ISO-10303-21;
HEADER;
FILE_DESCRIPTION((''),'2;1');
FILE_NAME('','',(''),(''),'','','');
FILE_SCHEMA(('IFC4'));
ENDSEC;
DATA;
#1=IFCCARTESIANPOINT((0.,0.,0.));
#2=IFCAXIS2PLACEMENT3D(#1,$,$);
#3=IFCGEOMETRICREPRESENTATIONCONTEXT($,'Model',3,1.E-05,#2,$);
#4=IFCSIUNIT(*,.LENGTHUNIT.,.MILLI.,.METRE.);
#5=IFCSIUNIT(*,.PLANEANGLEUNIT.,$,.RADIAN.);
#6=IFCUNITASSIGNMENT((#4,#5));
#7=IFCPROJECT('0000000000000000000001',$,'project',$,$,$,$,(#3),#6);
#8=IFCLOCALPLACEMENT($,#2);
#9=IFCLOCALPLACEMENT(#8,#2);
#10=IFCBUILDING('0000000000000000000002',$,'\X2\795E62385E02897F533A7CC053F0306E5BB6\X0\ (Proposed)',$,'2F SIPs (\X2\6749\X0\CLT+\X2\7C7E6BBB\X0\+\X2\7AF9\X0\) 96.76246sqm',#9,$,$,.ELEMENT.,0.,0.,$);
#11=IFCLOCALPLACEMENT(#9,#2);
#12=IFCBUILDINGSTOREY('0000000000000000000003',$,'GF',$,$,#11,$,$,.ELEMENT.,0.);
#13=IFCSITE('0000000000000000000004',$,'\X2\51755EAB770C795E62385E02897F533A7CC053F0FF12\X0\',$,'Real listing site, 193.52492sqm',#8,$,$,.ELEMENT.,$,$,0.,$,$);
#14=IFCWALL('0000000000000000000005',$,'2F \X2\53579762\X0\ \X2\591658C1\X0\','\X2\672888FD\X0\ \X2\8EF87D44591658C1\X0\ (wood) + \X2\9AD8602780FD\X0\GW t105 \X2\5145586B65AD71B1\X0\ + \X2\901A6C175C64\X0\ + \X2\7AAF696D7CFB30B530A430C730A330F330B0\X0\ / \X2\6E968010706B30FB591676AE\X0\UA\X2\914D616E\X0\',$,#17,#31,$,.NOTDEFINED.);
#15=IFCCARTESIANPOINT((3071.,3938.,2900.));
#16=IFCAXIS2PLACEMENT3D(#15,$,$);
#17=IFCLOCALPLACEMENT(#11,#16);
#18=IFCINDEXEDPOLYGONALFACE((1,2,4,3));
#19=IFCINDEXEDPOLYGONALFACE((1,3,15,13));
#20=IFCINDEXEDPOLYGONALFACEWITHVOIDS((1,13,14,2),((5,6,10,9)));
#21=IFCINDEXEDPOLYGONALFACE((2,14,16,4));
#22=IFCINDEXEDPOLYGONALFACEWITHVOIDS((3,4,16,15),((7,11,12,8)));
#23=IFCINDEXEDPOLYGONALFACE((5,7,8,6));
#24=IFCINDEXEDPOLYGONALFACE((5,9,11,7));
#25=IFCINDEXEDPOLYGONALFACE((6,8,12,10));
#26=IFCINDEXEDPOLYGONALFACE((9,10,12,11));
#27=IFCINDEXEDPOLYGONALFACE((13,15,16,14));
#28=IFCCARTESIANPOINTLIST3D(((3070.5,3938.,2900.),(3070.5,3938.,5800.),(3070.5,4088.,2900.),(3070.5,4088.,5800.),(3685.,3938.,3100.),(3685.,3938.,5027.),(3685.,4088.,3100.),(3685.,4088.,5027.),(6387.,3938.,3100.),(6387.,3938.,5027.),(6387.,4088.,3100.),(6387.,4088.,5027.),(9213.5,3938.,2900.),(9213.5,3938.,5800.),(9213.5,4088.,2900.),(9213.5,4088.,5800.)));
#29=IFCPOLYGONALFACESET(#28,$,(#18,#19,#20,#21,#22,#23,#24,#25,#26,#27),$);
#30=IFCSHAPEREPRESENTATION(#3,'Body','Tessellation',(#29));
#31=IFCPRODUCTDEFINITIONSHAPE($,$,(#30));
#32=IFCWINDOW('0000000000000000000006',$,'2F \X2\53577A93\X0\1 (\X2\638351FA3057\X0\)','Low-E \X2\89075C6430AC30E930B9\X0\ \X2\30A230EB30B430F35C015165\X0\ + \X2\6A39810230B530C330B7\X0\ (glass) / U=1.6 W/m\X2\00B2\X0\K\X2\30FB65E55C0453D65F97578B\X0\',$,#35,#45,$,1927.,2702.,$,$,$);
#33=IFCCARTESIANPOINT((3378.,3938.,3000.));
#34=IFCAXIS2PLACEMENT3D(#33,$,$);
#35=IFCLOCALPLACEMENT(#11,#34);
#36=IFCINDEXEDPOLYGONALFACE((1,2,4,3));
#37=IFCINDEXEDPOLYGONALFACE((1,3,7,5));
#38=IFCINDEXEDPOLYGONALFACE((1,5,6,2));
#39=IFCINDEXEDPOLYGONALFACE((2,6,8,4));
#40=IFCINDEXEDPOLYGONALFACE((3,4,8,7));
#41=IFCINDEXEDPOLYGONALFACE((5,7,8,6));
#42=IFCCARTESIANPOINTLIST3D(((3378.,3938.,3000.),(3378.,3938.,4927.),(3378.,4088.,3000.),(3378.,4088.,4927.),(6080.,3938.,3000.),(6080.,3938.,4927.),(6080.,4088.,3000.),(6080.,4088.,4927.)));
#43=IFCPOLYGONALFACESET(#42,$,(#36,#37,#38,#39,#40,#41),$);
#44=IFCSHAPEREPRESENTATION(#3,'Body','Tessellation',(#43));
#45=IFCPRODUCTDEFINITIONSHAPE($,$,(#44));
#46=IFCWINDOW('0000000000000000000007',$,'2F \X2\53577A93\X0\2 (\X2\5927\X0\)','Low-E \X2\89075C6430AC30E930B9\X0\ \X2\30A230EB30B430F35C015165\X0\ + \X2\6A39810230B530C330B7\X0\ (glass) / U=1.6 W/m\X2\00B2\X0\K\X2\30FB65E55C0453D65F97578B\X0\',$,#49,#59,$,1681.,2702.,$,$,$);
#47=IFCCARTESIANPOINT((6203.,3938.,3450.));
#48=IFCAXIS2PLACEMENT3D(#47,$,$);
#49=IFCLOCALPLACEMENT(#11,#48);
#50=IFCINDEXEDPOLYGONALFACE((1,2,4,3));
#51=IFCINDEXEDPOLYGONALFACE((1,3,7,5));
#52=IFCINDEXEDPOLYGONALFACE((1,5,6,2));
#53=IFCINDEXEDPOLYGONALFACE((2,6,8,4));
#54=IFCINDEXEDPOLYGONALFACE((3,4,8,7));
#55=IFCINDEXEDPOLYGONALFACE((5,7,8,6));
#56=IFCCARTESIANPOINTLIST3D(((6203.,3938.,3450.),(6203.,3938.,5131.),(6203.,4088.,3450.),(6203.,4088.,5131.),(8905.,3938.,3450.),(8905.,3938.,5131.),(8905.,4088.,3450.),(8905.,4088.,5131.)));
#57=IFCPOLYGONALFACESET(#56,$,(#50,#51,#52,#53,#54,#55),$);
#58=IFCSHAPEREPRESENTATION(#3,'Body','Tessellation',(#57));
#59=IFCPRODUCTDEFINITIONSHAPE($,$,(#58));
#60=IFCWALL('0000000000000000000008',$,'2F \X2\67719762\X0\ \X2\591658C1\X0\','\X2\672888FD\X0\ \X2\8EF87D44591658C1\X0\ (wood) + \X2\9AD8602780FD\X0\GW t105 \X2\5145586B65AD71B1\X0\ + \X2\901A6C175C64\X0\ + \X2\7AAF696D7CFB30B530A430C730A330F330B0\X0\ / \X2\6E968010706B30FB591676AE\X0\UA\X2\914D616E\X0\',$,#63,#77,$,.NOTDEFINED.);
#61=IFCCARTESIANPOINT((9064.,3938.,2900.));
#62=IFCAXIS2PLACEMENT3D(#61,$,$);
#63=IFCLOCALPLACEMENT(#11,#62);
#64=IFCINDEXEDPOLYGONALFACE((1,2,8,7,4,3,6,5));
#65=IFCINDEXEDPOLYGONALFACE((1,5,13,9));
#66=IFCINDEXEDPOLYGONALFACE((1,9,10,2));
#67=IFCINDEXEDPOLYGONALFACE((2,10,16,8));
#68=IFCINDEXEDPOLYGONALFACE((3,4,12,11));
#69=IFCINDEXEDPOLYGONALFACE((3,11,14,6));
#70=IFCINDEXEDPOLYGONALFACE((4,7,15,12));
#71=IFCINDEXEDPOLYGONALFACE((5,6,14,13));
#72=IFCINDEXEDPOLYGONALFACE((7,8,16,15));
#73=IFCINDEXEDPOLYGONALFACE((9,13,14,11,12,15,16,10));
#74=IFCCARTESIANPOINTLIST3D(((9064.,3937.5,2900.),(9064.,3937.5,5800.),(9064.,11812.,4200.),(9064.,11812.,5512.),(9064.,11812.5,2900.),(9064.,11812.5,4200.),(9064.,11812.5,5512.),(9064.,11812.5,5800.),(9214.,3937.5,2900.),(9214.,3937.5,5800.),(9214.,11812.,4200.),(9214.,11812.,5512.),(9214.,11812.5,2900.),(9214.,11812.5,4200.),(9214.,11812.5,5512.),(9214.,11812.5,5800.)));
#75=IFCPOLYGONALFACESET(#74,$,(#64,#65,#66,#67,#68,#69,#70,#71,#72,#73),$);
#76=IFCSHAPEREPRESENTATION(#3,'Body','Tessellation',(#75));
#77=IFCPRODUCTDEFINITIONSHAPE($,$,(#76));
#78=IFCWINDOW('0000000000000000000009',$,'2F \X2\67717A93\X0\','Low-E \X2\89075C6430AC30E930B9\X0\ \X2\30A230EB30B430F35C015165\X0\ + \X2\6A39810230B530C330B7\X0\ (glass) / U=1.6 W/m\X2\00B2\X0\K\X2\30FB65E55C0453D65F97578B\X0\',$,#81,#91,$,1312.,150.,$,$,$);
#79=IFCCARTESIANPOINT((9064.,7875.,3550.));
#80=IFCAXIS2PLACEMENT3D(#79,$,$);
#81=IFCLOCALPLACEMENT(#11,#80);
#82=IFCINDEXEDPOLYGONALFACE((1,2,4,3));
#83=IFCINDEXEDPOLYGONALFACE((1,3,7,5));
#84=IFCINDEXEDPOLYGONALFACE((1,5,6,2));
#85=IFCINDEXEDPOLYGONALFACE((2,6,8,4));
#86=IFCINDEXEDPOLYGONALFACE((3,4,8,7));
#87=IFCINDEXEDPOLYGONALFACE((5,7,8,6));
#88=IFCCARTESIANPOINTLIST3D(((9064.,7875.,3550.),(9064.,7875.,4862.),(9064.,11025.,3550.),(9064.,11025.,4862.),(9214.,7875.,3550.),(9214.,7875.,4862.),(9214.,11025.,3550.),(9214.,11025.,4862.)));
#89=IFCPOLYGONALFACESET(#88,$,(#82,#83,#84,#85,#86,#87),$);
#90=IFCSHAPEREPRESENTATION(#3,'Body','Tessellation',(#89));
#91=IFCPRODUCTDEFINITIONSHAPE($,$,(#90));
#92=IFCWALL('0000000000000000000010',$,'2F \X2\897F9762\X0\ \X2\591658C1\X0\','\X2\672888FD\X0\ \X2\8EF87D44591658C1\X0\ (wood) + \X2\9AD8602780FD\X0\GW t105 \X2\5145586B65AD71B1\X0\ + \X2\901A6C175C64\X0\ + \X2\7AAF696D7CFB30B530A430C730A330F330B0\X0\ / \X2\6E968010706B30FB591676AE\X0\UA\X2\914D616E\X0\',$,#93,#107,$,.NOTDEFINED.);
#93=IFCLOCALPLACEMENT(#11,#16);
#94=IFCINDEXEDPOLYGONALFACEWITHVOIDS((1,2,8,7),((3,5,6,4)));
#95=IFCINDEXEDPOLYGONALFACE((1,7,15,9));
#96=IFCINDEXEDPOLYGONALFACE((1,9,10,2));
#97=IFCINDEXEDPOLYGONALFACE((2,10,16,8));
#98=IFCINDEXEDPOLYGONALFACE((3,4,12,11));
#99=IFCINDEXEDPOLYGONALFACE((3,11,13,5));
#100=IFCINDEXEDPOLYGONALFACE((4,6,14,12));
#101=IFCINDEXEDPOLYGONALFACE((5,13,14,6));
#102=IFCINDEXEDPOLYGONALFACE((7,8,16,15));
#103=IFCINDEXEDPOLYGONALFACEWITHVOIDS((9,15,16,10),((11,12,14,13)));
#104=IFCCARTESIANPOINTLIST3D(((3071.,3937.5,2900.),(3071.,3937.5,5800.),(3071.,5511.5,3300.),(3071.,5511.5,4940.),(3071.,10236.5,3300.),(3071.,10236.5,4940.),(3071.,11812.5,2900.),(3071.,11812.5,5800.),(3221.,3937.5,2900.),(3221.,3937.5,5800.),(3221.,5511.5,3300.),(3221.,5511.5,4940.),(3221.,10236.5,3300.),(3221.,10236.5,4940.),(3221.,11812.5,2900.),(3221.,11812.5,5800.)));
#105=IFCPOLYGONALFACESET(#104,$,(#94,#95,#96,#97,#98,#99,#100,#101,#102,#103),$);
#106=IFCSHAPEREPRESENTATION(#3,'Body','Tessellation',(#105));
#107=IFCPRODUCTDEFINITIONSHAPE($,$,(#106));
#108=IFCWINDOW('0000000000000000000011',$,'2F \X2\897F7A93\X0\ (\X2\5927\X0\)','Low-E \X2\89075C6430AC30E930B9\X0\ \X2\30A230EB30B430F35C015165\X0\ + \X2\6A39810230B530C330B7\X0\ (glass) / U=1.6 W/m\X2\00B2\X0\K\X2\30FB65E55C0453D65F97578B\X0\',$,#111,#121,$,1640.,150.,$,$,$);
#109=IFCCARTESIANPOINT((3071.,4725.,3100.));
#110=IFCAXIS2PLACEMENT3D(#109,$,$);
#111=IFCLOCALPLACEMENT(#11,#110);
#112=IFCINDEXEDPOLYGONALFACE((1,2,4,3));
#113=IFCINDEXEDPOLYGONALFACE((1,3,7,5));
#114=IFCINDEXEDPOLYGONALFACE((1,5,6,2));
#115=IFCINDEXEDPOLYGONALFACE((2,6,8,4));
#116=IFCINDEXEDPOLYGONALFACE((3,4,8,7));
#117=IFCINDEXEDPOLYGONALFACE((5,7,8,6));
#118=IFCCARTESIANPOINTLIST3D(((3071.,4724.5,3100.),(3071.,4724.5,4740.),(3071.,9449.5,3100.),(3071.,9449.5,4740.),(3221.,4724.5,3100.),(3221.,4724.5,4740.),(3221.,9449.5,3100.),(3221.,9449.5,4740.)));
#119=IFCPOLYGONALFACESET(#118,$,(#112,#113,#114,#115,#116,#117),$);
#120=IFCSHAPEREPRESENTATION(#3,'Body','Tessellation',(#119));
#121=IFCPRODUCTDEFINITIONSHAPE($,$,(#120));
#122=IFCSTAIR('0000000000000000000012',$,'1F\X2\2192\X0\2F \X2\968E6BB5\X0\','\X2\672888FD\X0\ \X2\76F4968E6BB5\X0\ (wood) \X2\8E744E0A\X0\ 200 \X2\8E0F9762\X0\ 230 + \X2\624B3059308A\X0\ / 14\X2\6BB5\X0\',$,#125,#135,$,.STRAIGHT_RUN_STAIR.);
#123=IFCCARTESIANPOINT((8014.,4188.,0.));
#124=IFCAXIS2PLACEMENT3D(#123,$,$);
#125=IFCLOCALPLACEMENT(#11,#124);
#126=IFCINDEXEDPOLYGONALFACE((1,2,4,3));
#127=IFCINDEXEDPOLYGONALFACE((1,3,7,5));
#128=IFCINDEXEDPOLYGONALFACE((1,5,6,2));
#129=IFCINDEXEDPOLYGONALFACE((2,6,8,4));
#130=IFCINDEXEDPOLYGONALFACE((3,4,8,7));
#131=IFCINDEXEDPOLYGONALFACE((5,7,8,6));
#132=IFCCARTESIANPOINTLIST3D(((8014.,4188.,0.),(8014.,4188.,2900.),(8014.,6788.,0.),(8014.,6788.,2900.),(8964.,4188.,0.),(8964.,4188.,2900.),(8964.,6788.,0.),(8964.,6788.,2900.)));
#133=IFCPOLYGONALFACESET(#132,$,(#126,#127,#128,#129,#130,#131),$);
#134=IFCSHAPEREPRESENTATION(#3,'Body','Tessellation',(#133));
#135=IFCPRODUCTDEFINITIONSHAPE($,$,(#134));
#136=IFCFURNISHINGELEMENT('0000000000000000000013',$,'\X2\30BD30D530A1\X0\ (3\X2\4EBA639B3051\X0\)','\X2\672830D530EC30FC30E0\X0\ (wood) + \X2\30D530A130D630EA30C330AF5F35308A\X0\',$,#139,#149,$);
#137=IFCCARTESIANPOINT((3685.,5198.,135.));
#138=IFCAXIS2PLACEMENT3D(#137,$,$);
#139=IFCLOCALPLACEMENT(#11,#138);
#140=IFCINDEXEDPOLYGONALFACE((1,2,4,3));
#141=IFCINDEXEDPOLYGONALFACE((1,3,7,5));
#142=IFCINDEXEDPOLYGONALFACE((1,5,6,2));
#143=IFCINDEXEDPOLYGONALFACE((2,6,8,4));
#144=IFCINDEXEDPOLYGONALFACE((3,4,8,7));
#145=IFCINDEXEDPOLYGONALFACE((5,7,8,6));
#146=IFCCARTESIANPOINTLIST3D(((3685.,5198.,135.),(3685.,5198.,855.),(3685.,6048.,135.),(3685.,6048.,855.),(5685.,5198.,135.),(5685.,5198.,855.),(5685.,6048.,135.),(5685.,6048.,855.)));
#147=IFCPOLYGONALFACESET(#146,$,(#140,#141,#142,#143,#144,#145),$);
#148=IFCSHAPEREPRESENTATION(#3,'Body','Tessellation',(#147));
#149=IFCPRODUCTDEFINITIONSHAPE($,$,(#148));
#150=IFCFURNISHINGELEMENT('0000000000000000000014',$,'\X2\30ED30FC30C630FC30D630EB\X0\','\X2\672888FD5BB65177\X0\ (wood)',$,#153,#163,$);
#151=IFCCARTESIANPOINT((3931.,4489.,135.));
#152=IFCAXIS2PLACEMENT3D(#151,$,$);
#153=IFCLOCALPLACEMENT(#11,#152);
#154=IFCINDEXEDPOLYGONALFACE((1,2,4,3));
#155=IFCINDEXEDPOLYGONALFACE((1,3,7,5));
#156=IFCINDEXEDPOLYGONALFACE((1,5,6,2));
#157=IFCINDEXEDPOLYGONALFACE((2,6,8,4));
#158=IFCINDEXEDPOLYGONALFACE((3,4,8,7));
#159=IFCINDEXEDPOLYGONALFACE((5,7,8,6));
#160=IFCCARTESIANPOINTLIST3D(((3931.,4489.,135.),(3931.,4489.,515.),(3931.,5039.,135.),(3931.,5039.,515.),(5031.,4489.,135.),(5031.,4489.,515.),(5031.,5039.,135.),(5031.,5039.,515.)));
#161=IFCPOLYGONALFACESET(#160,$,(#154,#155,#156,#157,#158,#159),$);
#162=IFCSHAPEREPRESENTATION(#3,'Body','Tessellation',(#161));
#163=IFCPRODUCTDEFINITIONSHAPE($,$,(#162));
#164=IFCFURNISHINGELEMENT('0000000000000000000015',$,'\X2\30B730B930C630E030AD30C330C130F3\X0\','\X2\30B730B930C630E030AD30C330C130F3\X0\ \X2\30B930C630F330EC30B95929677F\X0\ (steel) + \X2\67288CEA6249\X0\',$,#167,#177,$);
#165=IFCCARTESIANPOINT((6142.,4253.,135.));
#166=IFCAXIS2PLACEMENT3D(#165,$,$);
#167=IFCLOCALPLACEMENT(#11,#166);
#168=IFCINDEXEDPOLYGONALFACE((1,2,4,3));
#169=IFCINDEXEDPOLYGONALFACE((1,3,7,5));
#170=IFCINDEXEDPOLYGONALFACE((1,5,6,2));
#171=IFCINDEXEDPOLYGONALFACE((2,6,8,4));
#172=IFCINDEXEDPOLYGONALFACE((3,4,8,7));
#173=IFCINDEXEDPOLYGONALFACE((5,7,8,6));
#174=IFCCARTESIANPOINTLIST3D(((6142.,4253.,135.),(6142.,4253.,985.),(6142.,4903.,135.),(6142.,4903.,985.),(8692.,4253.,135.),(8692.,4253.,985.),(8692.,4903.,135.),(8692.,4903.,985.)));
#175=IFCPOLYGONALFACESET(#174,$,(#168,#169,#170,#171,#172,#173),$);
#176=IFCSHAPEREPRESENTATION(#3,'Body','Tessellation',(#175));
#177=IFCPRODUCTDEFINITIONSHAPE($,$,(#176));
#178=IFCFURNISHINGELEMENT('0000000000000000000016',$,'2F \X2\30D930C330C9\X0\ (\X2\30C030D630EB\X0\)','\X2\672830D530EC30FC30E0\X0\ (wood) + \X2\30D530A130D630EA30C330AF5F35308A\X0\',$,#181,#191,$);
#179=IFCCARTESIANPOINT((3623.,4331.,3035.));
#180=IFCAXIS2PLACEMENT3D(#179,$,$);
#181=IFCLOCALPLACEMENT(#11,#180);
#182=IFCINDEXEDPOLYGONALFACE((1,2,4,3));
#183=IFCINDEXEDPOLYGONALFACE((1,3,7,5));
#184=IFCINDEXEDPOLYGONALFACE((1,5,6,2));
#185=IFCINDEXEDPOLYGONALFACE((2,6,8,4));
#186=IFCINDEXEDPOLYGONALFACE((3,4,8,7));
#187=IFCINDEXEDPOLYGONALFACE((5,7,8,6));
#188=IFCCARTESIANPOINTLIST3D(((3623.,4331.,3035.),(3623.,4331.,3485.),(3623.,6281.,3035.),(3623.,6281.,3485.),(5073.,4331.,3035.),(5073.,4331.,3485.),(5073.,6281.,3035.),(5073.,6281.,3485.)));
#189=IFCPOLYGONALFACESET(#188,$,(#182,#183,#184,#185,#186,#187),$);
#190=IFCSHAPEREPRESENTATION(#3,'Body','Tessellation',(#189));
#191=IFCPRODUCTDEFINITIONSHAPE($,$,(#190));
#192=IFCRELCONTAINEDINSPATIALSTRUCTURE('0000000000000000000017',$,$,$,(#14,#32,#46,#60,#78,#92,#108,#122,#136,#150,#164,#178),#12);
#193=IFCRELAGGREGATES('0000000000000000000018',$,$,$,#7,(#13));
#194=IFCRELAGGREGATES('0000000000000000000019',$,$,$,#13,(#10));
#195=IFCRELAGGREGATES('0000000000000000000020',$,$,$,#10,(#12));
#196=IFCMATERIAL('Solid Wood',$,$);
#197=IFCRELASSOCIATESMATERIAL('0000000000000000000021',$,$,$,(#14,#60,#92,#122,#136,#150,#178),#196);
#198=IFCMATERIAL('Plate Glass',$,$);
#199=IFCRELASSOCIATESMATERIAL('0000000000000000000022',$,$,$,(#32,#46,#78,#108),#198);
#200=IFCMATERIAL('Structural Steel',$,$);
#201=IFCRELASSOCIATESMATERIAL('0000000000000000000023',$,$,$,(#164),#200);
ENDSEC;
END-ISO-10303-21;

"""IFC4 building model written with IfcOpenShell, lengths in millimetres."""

from ifc_helpers import new_model, si_unit, frame, frame_2d, origin, place, context, project, spatial, rectangle, extrude, material, element, fill, save


model = new_model("IFC4")

# Units and contexts
model_context = context("Model", 3, precision=1e-05, world=origin())
ifc_project = project(units=[si_unit("LENGTHUNIT", "METRE", prefix="MILLI"), si_unit("PLANEANGLEUNIT", "RADIAN")], contexts=[model_context])

# Site, building, storey
site_placement = place(None, origin())
site = spatial("IfcSite", under=ifc_project, at=site_placement, Name="兵庫県神戸市西区糀台２", ObjectType="Real listing site, 193.52492sqm", CompositionType="ELEMENT", RefElevation=0.0)
building_placement = place(site_placement, origin())
building = spatial("IfcBuilding", under=site, at=building_placement, Name="神戸市西区糀台の家 (Proposed)", ObjectType="2F SIPs (杉CLT+籾殻+竹) 96.76246sqm", CompositionType="ELEMENT", ElevationOfRefHeight=0.0, ElevationOfTerrain=0.0)
storey_placement = place(building_placement, origin())
storey = spatial("IfcBuildingStorey", under=building, at=storey_placement, Name="GF", CompositionType="ELEMENT", Elevation=0.0)

# Shared definitions
ifc_material_1 = material(Name="Solid Wood")

# Shared definitions
ifc_material_2 = material(Name="Plate Glass")

# Wall, openings, windows
wall_1_placement = place(storey_placement, frame((3071.0, 3938.0, 2900.0)))
wall_1 = element("IfcWall", 1, at=wall_1_placement, inside=storey, material=ifc_material_1, Name="2F 南面 外壁", Description="木製 軸組外壁 (wood) + 高性能GW t105 充填断熱 + 通気層 + 窯業系サイディング / 準耐火・外皮UA配慮", PredefinedType="NOTDEFINED", context=model_context, shape_type="SweptSolid", body=[
    extrude(rectangle(XDim=6143.0, YDim=150.0, at=frame_2d((3071.0, 75.0))), frame((3071.0, 3938.0, 2900.0)), (0.0, 0.0, 1.0), 2900.0),
])
opening_1_placement = place(storey_placement, frame((3378.0, 3938.0, 3000.0)))
opening_1 = element("IfcOpeningElement", 2, at=opening_1_placement, cuts=wall_1, PredefinedType="NOTDEFINED", context=model_context, shape_type="SweptSolid", body=[
    extrude(rectangle(XDim=2702.0, YDim=150.0, at=frame_2d((1351.0, 75.0))), frame((3378.0, 3938.0, 3000.0)), (0.0, 0.0, 1.0), 1927.0),
])
opening_2_placement = place(storey_placement, frame((6203.0, 3938.0, 3450.0)))
opening_2 = element("IfcOpeningElement", 3, at=opening_2_placement, cuts=wall_1, PredefinedType="NOTDEFINED", context=model_context, shape_type="SweptSolid", body=[
    extrude(rectangle(XDim=2702.0, YDim=150.0, at=frame_2d((1351.0, 75.0))), frame((6203.0, 3938.0, 3450.0)), (0.0, 0.0, 1.0), 1681.0),
])
window_1_placement = place(storey_placement, frame((3378.0, 3938.0, 3000.0)))
window_1 = element("IfcWindow", 4, at=window_1_placement, inside=storey, material=ifc_material_2, Name="2F 南窓1 (掃出し)", Description="Low-E 複層ガラス アルゴン封入 + 樹脂サッシ (glass) / U=1.6 W/m²K・日射取得型", OverallHeight=1927.0, OverallWidth=2702.0, context=model_context, shape_type="SweptSolid", body=[
    extrude(rectangle(XDim=2702.0, YDim=150.0, at=frame_2d((1351.0, 75.0))), frame((3378.0, 3938.0, 3000.0)), (0.0, 0.0, 1.0), 1927.0),
])
fill(opening_1, window_1)
window_2_placement = place(storey_placement, frame((6203.0, 3938.0, 3450.0)))
window_2 = element("IfcWindow", 5, at=window_2_placement, inside=storey, material=ifc_material_2, Name="2F 南窓2 (大)", Description="Low-E 複層ガラス アルゴン封入 + 樹脂サッシ (glass) / U=1.6 W/m²K・日射取得型", OverallHeight=1681.0, OverallWidth=2702.0, context=model_context, shape_type="SweptSolid", body=[
    extrude(rectangle(XDim=2702.0, YDim=150.0, at=frame_2d((1351.0, 75.0))), frame((6203.0, 3938.0, 3450.0)), (0.0, 0.0, 1.0), 1681.0),
])
fill(opening_2, window_2)

# Walls, openings, windows
wall_2_placement = place(storey_placement, frame((9064.0, 3938.0, 2900.0)))
wall_2 = element("IfcWall", 6, at=wall_2_placement, inside=storey, material=ifc_material_1, Name="2F 東面 外壁", Description="木製 軸組外壁 (wood) + 高性能GW t105 充填断熱 + 通気層 + 窯業系サイディング / 準耐火・外皮UA配慮", PredefinedType="NOTDEFINED", context=model_context, shape_type="SweptSolid", body=[
    extrude(rectangle(XDim=150.0, YDim=7875.0, at=frame_2d((75.0, 3937.0))), frame((9064.0, 3938.0, 2900.0)), (0.0, 0.0, 1.0), 2900.0),
])
opening_3_placement = place(storey_placement, frame((9064.0, 7875.0, 3550.0)))
opening_3 = element("IfcOpeningElement", 7, at=opening_3_placement, cuts=wall_2, PredefinedType="NOTDEFINED", context=model_context, shape_type="SweptSolid", body=[
    extrude(rectangle(XDim=150.0, YDim=3150.0, at=frame_2d((75.0, 1575.0))), frame((9064.0, 7875.0, 3550.0)), (0.0, 0.0, 1.0), 1312.0),
])
window_3_placement = place(storey_placement, frame((9064.0, 7875.0, 3550.0)))
window_3 = element("IfcWindow", 8, at=window_3_placement, inside=storey, material=ifc_material_2, Name="2F 東窓", Description="Low-E 複層ガラス アルゴン封入 + 樹脂サッシ (glass) / U=1.6 W/m²K・日射取得型", OverallHeight=1312.0, OverallWidth=150.0, context=model_context, shape_type="SweptSolid", body=[
    extrude(rectangle(XDim=150.0, YDim=3150.0, at=frame_2d((75.0, 1575.0))), frame((9064.0, 7875.0, 3550.0)), (0.0, 0.0, 1.0), 1312.0),
])
fill(opening_3, window_3)
wall_3_placement = place(storey_placement, frame((3071.0, 3938.0, 2900.0)))
wall_3 = element("IfcWall", 9, at=wall_3_placement, inside=storey, material=ifc_material_1, Name="2F 西面 外壁", Description="木製 軸組外壁 (wood) + 高性能GW t105 充填断熱 + 通気層 + 窯業系サイディング / 準耐火・外皮UA配慮", PredefinedType="NOTDEFINED", context=model_context, shape_type="SweptSolid", body=[
    extrude(rectangle(XDim=150.0, YDim=7875.0, at=frame_2d((75.0, 3937.0))), frame((3071.0, 3938.0, 2900.0)), (0.0, 0.0, 1.0), 2900.0),
])
opening_4_placement = place(storey_placement, frame((3071.0, 4725.0, 3100.0)))
opening_4 = element("IfcOpeningElement", 10, at=opening_4_placement, cuts=wall_3, PredefinedType="NOTDEFINED", context=model_context, shape_type="SweptSolid", body=[
    extrude(rectangle(XDim=150.0, YDim=4725.0, at=frame_2d((75.0, 2362.0))), frame((3071.0, 4725.0, 3100.0)), (0.0, 0.0, 1.0), 1640.0),
])
window_4_placement = place(storey_placement, frame((3071.0, 4725.0, 3100.0)))
window_4 = element("IfcWindow", 11, at=window_4_placement, inside=storey, material=ifc_material_2, Name="2F 西窓 (大)", Description="Low-E 複層ガラス アルゴン封入 + 樹脂サッシ (glass) / U=1.6 W/m²K・日射取得型", OverallHeight=1640.0, OverallWidth=150.0, context=model_context, shape_type="SweptSolid", body=[
    extrude(rectangle(XDim=150.0, YDim=4725.0, at=frame_2d((75.0, 2362.0))), frame((3071.0, 4725.0, 3100.0)), (0.0, 0.0, 1.0), 1640.0),
])
fill(opening_4, window_4)

# Stair
stair_placement = place(storey_placement, frame((8014.0, 4188.0, 0.0)))
element("IfcStair", 12, at=stair_placement, inside=storey, material=ifc_material_1, Name="1F→2F 階段", Description="木製 直階段 (wood) 蹴上 200 踏面 230 + 手すり / 14段", PredefinedType="STRAIGHT_RUN_STAIR", context=model_context, shape_type="SweptSolid", body=[
    extrude(rectangle(XDim=950.0, YDim=2600.0, at=frame_2d((475.0, 1300.0))), frame((8014.0, 4188.0, 0.0)), (0.0, 0.0, 1.0), 2900.0),
])

# Shared definitions
ifc_material_3 = material(Name="Structural Steel")

# Furnishing elements
furnishing_1_placement = place(storey_placement, frame((3685.0, 5198.0, 135.0)))
element("IfcFurnishingElement", 13, at=furnishing_1_placement, inside=storey, material=ifc_material_1, Name="ソファ (3人掛け)", Description="木フレーム (wood) + ファブリック張り", context=model_context, shape_type="SweptSolid", body=[
    extrude(rectangle(XDim=2000.0, YDim=850.0, at=frame_2d((1000.0, 425.0))), frame((3685.0, 5198.0, 135.0)), (0.0, 0.0, 1.0), 720.0),
])
furnishing_2_placement = place(storey_placement, frame((3931.0, 4489.0, 135.0)))
element("IfcFurnishingElement", 14, at=furnishing_2_placement, inside=storey, material=ifc_material_1, Name="ローテーブル", Description="木製家具 (wood)", context=model_context, shape_type="SweptSolid", body=[
    extrude(rectangle(XDim=1100.0, YDim=550.0, at=frame_2d((550.0, 275.0))), frame((3931.0, 4489.0, 135.0)), (0.0, 0.0, 1.0), 380.0),
])
furnishing_3_placement = place(storey_placement, frame((6142.0, 4253.0, 135.0)))
element("IfcFurnishingElement", 15, at=furnishing_3_placement, inside=storey, material=ifc_material_3, Name="システムキッチン", Description="システムキッチン ステンレス天板 (steel) + 木質扉", context=model_context, shape_type="SweptSolid", body=[
    extrude(rectangle(XDim=2550.0, YDim=650.0, at=frame_2d((1275.0, 325.0))), frame((6142.0, 4253.0, 135.0)), (0.0, 0.0, 1.0), 850.0),
])
furnishing_4_placement = place(storey_placement, frame((3623.0, 4331.0, 3035.0)))
element("IfcFurnishingElement", 16, at=furnishing_4_placement, inside=storey, material=ifc_material_1, Name="2F ベッド (ダブル)", Description="木フレーム (wood) + ファブリック張り", context=model_context, shape_type="SweptSolid", body=[
    extrude(rectangle(XDim=1450.0, YDim=1950.0, at=frame_2d((725.0, 975.0))), frame((3623.0, 4331.0, 3035.0)), (0.0, 0.0, 1.0), 450.0),
])

save(model, "model.ifc")
